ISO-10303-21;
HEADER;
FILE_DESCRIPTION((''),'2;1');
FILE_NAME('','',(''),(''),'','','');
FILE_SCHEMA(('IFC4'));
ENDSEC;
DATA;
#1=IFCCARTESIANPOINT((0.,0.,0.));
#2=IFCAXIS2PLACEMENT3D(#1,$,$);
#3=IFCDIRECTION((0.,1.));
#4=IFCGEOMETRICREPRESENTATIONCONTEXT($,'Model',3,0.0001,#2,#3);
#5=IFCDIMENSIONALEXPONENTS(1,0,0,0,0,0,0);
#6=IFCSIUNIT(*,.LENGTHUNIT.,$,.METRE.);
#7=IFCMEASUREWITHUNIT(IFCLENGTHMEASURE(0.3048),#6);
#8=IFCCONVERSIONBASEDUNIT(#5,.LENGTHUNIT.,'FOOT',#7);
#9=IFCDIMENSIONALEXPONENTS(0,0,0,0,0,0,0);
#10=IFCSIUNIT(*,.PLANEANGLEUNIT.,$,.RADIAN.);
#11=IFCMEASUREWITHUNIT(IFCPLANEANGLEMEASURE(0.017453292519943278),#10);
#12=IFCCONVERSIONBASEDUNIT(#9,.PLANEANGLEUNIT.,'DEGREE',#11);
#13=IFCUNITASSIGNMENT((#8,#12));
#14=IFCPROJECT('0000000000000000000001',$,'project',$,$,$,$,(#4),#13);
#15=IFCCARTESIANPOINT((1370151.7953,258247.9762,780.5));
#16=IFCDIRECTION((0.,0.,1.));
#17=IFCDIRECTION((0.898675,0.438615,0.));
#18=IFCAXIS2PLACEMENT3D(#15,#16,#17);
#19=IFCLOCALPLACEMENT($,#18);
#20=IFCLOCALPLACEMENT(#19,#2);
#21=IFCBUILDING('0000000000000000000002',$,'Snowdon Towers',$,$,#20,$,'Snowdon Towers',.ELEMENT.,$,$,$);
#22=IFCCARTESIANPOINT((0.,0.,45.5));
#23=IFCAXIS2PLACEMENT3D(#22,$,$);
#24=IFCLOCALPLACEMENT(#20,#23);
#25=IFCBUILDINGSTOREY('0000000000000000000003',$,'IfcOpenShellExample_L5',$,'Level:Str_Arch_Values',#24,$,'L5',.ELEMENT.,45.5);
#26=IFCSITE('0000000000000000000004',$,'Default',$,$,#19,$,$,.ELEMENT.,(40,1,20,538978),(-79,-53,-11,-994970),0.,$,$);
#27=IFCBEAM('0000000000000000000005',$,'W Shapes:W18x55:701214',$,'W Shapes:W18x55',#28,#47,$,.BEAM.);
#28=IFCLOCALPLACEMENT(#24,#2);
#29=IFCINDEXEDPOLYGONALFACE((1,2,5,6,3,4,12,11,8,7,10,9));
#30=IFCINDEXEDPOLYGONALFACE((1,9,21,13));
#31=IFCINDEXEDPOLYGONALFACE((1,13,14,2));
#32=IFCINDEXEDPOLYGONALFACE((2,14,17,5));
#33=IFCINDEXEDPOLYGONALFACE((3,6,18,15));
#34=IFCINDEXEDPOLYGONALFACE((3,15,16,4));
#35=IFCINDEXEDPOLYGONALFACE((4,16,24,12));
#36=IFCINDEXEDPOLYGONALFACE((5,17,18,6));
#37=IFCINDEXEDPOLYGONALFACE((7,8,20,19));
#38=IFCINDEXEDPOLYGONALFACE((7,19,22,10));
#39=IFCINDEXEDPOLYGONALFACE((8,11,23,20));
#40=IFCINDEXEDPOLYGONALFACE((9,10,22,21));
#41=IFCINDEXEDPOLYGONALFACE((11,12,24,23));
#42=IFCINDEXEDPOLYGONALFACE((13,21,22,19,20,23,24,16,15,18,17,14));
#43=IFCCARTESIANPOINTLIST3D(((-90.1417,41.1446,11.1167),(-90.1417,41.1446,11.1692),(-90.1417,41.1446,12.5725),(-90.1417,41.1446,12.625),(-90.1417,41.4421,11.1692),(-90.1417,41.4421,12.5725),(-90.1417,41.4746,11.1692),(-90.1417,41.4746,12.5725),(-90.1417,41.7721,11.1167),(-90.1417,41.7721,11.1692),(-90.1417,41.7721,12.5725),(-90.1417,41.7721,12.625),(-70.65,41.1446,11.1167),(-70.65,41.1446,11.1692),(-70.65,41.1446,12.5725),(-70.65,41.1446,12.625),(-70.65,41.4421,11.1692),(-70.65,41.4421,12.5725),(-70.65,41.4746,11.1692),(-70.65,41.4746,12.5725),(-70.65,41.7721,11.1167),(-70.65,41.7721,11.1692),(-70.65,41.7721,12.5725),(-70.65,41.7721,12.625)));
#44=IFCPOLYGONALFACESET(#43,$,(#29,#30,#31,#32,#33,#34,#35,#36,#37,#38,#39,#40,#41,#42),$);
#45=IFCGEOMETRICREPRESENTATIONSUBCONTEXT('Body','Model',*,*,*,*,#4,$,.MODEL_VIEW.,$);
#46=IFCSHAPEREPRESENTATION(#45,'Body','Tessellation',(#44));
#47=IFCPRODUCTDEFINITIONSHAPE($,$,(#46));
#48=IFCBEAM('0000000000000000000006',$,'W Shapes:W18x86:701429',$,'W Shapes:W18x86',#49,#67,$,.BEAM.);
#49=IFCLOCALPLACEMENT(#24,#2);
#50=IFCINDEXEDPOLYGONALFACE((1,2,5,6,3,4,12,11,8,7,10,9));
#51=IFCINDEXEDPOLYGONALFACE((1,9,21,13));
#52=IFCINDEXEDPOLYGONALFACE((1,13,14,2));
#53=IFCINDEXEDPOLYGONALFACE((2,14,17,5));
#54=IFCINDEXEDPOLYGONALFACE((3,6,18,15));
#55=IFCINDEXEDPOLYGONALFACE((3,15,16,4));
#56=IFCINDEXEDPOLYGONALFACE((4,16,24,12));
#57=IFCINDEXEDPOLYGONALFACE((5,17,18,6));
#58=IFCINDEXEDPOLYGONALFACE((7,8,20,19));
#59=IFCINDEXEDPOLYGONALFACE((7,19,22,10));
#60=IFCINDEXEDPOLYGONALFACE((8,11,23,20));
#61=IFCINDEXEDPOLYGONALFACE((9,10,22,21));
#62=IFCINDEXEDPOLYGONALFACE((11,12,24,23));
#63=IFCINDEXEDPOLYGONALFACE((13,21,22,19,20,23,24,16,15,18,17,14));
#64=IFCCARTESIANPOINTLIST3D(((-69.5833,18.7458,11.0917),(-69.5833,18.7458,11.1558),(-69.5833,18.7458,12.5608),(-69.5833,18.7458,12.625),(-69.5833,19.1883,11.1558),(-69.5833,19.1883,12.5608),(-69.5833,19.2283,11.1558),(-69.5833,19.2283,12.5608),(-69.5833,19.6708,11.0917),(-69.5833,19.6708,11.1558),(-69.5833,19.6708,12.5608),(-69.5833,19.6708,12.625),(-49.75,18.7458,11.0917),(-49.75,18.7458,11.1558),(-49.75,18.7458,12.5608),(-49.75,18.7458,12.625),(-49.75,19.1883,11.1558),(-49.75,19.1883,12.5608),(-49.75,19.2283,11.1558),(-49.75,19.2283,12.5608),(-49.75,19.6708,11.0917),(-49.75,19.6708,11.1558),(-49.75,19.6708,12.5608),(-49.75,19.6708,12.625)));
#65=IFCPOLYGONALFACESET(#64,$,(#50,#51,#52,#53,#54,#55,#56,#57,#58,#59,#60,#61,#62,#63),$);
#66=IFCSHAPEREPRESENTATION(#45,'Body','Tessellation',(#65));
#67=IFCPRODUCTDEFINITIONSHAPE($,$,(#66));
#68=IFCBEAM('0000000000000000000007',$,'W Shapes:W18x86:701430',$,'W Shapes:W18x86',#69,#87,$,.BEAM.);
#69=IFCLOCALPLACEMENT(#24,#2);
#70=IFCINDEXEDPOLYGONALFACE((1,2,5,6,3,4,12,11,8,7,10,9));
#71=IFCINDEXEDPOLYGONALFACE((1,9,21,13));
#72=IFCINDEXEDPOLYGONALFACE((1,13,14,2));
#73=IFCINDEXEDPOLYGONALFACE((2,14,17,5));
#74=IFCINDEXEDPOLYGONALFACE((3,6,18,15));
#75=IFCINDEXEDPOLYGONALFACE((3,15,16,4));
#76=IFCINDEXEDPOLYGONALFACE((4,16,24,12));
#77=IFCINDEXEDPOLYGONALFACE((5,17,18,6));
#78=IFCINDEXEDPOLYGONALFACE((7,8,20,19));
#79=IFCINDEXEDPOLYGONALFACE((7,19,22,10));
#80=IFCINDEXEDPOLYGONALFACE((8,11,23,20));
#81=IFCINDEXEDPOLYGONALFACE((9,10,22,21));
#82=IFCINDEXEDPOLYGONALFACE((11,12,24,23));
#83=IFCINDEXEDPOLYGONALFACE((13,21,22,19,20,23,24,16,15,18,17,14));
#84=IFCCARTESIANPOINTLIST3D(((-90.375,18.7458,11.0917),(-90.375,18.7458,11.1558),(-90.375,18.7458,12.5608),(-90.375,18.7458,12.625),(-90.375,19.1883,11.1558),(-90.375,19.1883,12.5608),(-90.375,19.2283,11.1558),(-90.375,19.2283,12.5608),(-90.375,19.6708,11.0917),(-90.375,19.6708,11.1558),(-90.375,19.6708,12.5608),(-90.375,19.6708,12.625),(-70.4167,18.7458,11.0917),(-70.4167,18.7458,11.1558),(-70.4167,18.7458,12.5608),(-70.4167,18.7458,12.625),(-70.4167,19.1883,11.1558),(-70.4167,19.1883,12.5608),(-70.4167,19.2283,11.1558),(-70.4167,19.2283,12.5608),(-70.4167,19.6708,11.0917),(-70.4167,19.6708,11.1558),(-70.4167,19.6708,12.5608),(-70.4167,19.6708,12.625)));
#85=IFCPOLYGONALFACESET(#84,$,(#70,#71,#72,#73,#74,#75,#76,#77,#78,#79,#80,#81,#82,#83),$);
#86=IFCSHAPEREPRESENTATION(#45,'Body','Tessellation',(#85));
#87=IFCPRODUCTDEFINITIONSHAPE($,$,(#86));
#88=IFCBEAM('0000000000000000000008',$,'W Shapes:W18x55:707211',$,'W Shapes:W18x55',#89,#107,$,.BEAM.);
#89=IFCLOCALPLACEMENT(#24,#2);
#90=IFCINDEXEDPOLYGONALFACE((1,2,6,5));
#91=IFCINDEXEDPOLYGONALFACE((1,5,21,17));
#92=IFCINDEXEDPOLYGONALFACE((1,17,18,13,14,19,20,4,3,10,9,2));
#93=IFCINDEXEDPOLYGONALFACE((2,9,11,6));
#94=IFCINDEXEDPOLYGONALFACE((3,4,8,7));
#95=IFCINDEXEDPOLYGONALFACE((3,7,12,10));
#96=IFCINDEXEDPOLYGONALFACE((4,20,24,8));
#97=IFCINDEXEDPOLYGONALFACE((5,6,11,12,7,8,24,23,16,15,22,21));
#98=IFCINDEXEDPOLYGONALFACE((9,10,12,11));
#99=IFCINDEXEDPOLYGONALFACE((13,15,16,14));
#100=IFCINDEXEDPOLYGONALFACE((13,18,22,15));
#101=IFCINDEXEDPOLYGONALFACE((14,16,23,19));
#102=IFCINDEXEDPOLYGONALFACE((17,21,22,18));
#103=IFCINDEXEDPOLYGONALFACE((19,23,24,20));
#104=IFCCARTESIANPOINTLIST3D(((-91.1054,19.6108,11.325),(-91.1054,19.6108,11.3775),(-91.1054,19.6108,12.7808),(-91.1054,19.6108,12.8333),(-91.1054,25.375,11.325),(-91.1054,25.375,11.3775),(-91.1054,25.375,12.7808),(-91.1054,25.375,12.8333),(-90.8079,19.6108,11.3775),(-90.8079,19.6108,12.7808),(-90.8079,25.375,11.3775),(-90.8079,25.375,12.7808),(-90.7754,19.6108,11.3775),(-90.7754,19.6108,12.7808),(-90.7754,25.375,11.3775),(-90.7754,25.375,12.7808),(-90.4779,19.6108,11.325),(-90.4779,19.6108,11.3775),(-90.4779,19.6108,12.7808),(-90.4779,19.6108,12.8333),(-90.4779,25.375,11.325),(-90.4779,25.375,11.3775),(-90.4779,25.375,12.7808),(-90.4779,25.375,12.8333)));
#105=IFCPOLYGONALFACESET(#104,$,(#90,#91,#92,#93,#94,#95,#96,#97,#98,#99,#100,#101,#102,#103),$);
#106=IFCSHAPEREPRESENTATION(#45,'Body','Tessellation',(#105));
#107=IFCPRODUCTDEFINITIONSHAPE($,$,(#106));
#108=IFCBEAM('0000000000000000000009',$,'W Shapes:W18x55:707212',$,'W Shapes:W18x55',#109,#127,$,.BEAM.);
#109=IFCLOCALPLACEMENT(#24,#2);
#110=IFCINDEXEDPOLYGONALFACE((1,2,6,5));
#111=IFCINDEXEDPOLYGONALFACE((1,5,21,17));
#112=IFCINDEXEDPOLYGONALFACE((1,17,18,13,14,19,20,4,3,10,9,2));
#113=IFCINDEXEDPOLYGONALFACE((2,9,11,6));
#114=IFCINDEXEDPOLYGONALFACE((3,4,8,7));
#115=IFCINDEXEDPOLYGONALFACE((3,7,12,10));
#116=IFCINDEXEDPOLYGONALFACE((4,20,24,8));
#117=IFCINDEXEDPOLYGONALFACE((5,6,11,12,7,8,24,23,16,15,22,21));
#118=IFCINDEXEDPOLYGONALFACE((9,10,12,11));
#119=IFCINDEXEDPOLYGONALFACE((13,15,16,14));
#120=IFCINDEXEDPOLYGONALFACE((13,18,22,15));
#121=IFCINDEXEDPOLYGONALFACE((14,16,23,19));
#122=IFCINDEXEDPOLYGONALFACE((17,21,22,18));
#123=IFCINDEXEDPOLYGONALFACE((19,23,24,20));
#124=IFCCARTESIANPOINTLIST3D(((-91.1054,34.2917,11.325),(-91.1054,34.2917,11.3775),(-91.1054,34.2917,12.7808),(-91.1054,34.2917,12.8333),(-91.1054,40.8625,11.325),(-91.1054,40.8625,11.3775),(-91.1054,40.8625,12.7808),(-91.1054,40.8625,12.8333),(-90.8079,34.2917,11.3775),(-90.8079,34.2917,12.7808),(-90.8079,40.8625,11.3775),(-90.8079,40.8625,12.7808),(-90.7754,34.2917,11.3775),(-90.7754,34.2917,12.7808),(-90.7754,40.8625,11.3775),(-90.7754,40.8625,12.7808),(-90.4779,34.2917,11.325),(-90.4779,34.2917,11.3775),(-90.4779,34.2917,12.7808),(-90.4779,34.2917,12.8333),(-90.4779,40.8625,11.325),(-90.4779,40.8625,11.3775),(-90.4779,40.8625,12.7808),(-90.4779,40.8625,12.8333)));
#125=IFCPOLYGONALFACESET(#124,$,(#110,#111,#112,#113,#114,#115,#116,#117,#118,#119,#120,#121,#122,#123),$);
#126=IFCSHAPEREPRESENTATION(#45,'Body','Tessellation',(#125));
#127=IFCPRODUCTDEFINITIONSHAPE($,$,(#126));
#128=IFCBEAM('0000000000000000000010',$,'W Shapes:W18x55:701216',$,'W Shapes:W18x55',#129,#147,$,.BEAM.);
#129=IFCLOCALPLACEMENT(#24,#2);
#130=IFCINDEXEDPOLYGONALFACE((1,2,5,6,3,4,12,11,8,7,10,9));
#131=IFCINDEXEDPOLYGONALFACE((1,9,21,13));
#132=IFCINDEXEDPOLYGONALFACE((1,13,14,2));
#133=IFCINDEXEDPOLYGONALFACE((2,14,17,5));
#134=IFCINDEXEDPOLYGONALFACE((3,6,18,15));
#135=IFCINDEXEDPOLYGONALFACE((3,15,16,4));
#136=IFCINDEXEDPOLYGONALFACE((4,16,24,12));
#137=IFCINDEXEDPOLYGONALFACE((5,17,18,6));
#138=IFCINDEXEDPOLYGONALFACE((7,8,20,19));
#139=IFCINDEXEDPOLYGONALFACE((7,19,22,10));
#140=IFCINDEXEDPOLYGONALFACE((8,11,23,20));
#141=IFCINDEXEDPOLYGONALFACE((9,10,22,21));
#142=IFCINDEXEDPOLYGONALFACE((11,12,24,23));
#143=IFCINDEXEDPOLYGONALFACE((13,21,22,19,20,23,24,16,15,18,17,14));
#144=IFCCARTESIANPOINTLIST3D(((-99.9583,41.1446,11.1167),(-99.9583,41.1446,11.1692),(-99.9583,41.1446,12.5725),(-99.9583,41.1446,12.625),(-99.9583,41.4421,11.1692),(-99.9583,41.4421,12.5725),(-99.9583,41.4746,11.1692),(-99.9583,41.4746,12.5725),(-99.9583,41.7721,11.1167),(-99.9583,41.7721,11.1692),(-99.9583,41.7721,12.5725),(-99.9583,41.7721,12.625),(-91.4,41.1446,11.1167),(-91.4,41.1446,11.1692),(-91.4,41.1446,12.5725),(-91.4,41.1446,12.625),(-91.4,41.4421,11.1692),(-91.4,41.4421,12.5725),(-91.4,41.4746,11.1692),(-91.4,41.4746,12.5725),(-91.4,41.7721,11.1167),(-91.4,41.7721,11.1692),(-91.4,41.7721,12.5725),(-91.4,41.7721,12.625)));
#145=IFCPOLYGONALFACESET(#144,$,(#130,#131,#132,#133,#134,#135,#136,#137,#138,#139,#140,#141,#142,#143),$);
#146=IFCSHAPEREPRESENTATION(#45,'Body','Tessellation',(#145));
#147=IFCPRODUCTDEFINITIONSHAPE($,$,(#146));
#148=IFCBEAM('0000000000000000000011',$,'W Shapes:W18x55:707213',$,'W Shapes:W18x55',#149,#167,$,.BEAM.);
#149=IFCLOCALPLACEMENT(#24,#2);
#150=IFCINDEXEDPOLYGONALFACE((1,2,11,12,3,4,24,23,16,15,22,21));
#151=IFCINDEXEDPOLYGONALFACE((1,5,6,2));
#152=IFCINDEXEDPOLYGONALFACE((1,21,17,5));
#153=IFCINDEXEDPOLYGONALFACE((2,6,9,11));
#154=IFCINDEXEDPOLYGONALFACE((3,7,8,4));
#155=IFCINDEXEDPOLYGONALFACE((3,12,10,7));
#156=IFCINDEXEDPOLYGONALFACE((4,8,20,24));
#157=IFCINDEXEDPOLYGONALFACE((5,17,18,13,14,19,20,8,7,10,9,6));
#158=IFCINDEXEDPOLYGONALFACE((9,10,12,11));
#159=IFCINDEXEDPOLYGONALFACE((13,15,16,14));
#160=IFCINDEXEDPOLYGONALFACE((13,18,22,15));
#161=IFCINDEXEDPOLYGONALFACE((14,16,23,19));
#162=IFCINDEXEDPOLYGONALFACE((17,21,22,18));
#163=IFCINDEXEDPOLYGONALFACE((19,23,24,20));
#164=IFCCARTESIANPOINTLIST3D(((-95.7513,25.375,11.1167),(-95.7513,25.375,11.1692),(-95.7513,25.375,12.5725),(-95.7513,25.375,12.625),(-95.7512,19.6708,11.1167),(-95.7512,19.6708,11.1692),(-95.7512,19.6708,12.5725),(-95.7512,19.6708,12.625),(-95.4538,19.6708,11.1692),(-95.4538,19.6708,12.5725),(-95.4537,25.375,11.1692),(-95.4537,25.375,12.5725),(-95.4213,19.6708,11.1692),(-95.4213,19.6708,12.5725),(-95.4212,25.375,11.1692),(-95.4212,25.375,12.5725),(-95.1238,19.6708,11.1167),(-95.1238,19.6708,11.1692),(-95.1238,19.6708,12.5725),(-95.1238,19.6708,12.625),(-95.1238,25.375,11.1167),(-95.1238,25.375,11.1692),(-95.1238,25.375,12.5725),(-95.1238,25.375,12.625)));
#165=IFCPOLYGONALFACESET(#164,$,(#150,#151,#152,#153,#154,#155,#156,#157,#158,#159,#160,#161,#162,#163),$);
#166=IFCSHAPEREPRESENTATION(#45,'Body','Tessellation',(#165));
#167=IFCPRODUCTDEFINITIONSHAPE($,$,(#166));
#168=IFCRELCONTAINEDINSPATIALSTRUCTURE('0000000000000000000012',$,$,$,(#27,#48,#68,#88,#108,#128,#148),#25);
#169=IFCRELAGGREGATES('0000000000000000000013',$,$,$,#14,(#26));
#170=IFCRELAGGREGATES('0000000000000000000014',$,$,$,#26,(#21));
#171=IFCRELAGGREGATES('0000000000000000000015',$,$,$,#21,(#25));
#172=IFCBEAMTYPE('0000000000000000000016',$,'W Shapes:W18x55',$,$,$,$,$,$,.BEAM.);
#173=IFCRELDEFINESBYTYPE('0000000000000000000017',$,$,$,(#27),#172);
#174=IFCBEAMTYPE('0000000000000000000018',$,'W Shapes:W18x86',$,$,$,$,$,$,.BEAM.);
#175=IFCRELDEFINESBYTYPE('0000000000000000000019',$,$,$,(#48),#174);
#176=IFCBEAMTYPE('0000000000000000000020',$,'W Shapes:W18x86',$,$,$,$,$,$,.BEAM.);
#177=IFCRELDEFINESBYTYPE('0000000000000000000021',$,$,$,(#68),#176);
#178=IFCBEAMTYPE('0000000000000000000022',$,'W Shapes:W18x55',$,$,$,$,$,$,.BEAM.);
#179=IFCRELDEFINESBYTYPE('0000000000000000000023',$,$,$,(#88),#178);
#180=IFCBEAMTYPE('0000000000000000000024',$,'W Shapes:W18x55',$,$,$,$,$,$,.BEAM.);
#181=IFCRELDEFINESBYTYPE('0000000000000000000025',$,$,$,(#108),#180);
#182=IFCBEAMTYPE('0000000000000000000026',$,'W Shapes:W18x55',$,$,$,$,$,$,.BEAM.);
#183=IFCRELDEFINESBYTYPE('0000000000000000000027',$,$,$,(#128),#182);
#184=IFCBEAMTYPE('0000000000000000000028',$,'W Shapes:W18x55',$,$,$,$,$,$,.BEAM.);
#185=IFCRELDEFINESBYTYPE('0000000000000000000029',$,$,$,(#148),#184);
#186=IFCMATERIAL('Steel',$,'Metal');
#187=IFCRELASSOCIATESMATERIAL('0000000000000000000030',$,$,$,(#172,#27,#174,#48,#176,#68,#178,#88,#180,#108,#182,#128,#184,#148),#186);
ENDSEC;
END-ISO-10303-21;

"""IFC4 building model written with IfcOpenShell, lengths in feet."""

from ifc_helpers import new_model, entity, si_unit, converted_unit, direction, frame, origin, place, context, subcontext, project, spatial, indexed_curve, outline, extrude, source, transform, mapped, material, type_object, type_shapes, element, save


model = new_model("IFC4")

# Units and contexts
model_context = context("Model", 3, precision=0.0001, world=origin(), true_north=direction((0.0, 1.0)))
body_context = subcontext(model_context, "Body", "Model", "MODEL_VIEW")
ifc_project = project(units=[converted_unit("LENGTHUNIT", "FOOT", entity("IfcLengthMeasure", 0.3048), si_unit("LENGTHUNIT", "METRE"), dimensions=[1, 0, 0, 0, 0, 0, 0]), converted_unit("PLANEANGLEUNIT", "DEGREE", entity("IfcPlaneAngleMeasure", 0.017453292519943278), si_unit("PLANEANGLEUNIT", "RADIAN"), dimensions=[0, 0, 0, 0, 0, 0, 0])], contexts=[model_context])

# Site, building, storey
site_placement = place(None, frame((1370151.7953, 258247.9762, 780.5), z_axis=(0.0, 0.0, 1.0), x_axis=(0.898675, 0.438615, 0.0)))
site = spatial("IfcSite", under=ifc_project, at=site_placement, Name="Default", CompositionType="ELEMENT", RefLatitude=(40, 1, 20, 538978), RefLongitude=(-79, -53, -11, -994970), RefElevation=0.0)
building_placement = place(site_placement, origin())
building = spatial("IfcBuilding", under=site, at=building_placement, Name="Snowdon Towers", LongName="Snowdon Towers", CompositionType="ELEMENT")
storey_placement = place(building_placement, frame((0.0, 0.0, 45.5)))
storey = spatial("IfcBuildingStorey", under=building, at=storey_placement, Name="IfcOpenShellExample_L5", ObjectType="Level:Str_Arch_Values", LongName="L5", CompositionType="ELEMENT", Elevation=45.5)

# Beams
ifc_material = material(Name="Steel", Category="Metal")
beam_type_1 = type_object("IfcBeamType", Name="W Shapes:W18x55", PredefinedType="BEAM", material=ifc_material)
shared_shape_1 = source(origin(), body_context, "Body", "SweptSolid", [
    extrude(outline(indexed_curve([(-0.3138, -0.7017), (-0.3138, -0.7542), (0.3138, -0.7542), (0.3138, -0.7017), (0.0162, -0.7017), (0.0162, 0.7017), (0.3138, 0.7017), (0.3138, 0.7542), (-0.3137, 0.7542), (-0.3137, 0.7017), (-0.0163, 0.7017), (-0.0163, -0.7017), (-0.3138, -0.7017)], self_intersect=False)), frame((-9.7875, 0.0, 0.0), z_axis=(-1.0, 0.0, 0.0), x_axis=(0.0, -1.0, 0.0)), (0.0, 0.0, -1.0), 19.4917),
])
type_shapes(beam_type_1, [shared_shape_1])
beam_1_placement = place(storey_placement, frame((-80.3542, 41.4583, 11.8708)))
element("IfcBeam", 1, at=beam_1_placement, inside=storey, type_object=beam_type_1, material=ifc_material, Name="W Shapes:W18x55:701214", ObjectType="W Shapes:W18x55", PredefinedType="BEAM", context=body_context, shape_type="MappedRepresentation", body=[
    mapped(shared_shape_1, transform((0.0, 0.0, 0.0), scale=1.0)),
])
beam_type_2 = type_object("IfcBeamType", Name="W Shapes:W18x86", PredefinedType="BEAM", material=ifc_material)
shared_shape_2 = source(origin(), body_context, "Body", "SweptSolid", [
    extrude(outline(indexed_curve([(-0.4625, -0.7025), (-0.4625, -0.7667), (0.4625, -0.7667), (0.4625, -0.7025), (0.02, -0.7025), (0.02, 0.7025), (0.4625, 0.7025), (0.4625, 0.7667), (-0.4625, 0.7667), (-0.4625, 0.7025), (-0.02, 0.7025), (-0.02, -0.7025), (-0.4625, -0.7025)], self_intersect=False)), frame((-9.9583, 0.0, 0.0), z_axis=(-1.0, 0.0, 0.0), x_axis=(0.0, -1.0, 0.0)), (0.0, 0.0, -1.0), 19.8333),
])
type_shapes(beam_type_2, [shared_shape_2])
beam_2_placement = place(storey_placement, frame((-59.625, 19.2083, 11.8583)))
element("IfcBeam", 2, at=beam_2_placement, inside=storey, type_object=beam_type_2, material=ifc_material, Name="W Shapes:W18x86:701429", ObjectType="W Shapes:W18x86", PredefinedType="BEAM", context=body_context, shape_type="MappedRepresentation", body=[
    mapped(shared_shape_2, transform((0.0, 0.0, 0.0), scale=1.0)),
])
beam_type_3 = type_object("IfcBeamType", Name="W Shapes:W18x86", PredefinedType="BEAM", material=ifc_material)
shared_shape_3 = source(origin(), body_context, "Body", "SweptSolid", [
    extrude(outline(indexed_curve([(-0.4625, -0.7025), (-0.4625, -0.7667), (0.4625, -0.7667), (0.4625, -0.7025), (0.02, -0.7025), (0.02, 0.7025), (0.4625, 0.7025), (0.4625, 0.7667), (-0.4625, 0.7667), (-0.4625, 0.7025), (-0.02, 0.7025), (-0.02, -0.7025), (-0.4625, -0.7025)], self_intersect=False)), frame((-10.0, 0.0, 0.0), z_axis=(-1.0, 0.0, 0.0), x_axis=(0.0, -1.0, 0.0)), (0.0, 0.0, -1.0), 19.9583),
])
type_shapes(beam_type_3, [shared_shape_3])
beam_3_placement = place(storey_placement, frame((-80.375, 19.2083, 11.8583)))
element("IfcBeam", 3, at=beam_3_placement, inside=storey, type_object=beam_type_3, material=ifc_material, Name="W Shapes:W18x86:701430", ObjectType="W Shapes:W18x86", PredefinedType="BEAM", context=body_context, shape_type="MappedRepresentation", body=[
    mapped(shared_shape_3, transform((0.0, 0.0, 0.0), scale=1.0)),
])
beam_type_4 = type_object("IfcBeamType", Name="W Shapes:W18x55", PredefinedType="BEAM", material=ifc_material)
shared_shape_4 = source(origin(), body_context, "Body", "SweptSolid", [
    extrude(outline(indexed_curve([(-0.3138, -0.7017), (-0.3138, -0.7542), (0.3138, -0.7542), (0.3138, -0.7017), (0.0162, -0.7017), (0.0162, 0.7017), (0.3138, 0.7017), (0.3138, 0.7542), (-0.3137, 0.7542), (-0.3137, 0.7017), (-0.0163, 0.7017), (-0.0163, -0.7017), (-0.3138, -0.7017)], self_intersect=False)), frame((-2.6737, 0.0, 0.0), z_axis=(-1.0, 0.0, 0.0), x_axis=(0.0, -1.0, 0.0)), (0.0, 0.0, -1.0), 5.7642),
])
type_shapes(beam_type_4, [shared_shape_4])
beam_4_placement = place(storey_placement, frame((-90.7917, 22.2846, 12.0792), z_axis=(0.0, 0.0, 1.0), x_axis=(0.0, 1.0, 0.0)))
element("IfcBeam", 4, at=beam_4_placement, inside=storey, type_object=beam_type_4, material=ifc_material, Name="W Shapes:W18x55:707211", ObjectType="W Shapes:W18x55", PredefinedType="BEAM", context=body_context, shape_type="MappedRepresentation", body=[
    mapped(shared_shape_4, transform((0.0, 0.0, 0.0), scale=1.0)),
])
beam_type_5 = type_object("IfcBeamType", Name="W Shapes:W18x55", PredefinedType="BEAM", material=ifc_material)
shared_shape_5 = source(origin(), body_context, "Body", "SweptSolid", [
    extrude(outline(indexed_curve([(-0.3138, -0.7017), (-0.3138, -0.7542), (0.3138, -0.7542), (0.3138, -0.7017), (0.0162, -0.7017), (0.0162, 0.7017), (0.3138, 0.7017), (0.3138, 0.7542), (-0.3137, 0.7542), (-0.3137, 0.7017), (-0.0163, 0.7017), (-0.0163, -0.7017), (-0.3138, -0.7017)], self_intersect=False)), frame((-3.1958, 0.0, 0.0), z_axis=(-1.0, 0.0, 0.0), x_axis=(0.0, -1.0, 0.0)), (0.0, 0.0, -1.0), 6.5708),
])
type_shapes(beam_type_5, [shared_shape_5])
beam_5_placement = place(storey_placement, frame((-90.7917, 37.6667, 12.0792), z_axis=(0.0, 0.0, 1.0), x_axis=(0.0, -1.0, 0.0)))
element("IfcBeam", 5, at=beam_5_placement, inside=storey, type_object=beam_type_5, material=ifc_material, Name="W Shapes:W18x55:707212", ObjectType="W Shapes:W18x55", PredefinedType="BEAM", context=body_context, shape_type="MappedRepresentation", body=[
    mapped(shared_shape_5, transform((0.0, 0.0, 0.0), scale=1.0)),
])
beam_type_6 = type_object("IfcBeamType", Name="W Shapes:W18x55", PredefinedType="BEAM", material=ifc_material)
shared_shape_6 = source(origin(), body_context, "Body", "SweptSolid", [
    extrude(outline(indexed_curve([(-0.3138, -0.7017), (-0.3138, -0.7542), (0.3138, -0.7542), (0.3138, -0.7017), (0.0162, -0.7017), (0.0162, 0.7017), (0.3138, 0.7017), (0.3138, 0.7542), (-0.3137, 0.7542), (-0.3137, 0.7017), (-0.0163, 0.7017), (-0.0163, -0.7017), (-0.3138, -0.7017)], self_intersect=False)), frame((-4.6042, 0.0, 0.0), z_axis=(-1.0, 0.0, 0.0), x_axis=(0.0, -1.0, 0.0)), (0.0, 0.0, -1.0), 8.5583),
])
type_shapes(beam_type_6, [shared_shape_6])
beam_6_placement = place(storey_placement, frame((-95.3542, 41.4583, 11.8708)))
element("IfcBeam", 6, at=beam_6_placement, inside=storey, type_object=beam_type_6, material=ifc_material, Name="W Shapes:W18x55:701216", ObjectType="W Shapes:W18x55", PredefinedType="BEAM", context=body_context, shape_type="MappedRepresentation", body=[
    mapped(shared_shape_6, transform((0.0, 0.0, 0.0), scale=1.0)),
])
beam_type_7 = type_object("IfcBeamType", Name="W Shapes:W18x55", PredefinedType="BEAM", material=ifc_material)
shared_shape_7 = source(origin(), body_context, "Body", "SweptSolid", [
    extrude(outline(indexed_curve([(-0.3138, -0.7017), (-0.3138, -0.7542), (0.3138, -0.7542), (0.3138, -0.7017), (0.0162, -0.7017), (0.0162, 0.7017), (0.3138, 0.7017), (0.3138, 0.7542), (-0.3137, 0.7542), (-0.3137, 0.7017), (-0.0163, 0.7017), (-0.0163, -0.7017), (-0.3138, -0.7017)], self_intersect=False)), frame((-2.6208, 0.0, 0.0), z_axis=(-1.0, 0.0, 0.0), x_axis=(0.0, -1.0, 0.0)), (0.0, 0.0, -1.0), 5.7042),
])
type_shapes(beam_type_7, [shared_shape_7])
beam_7_placement = place(storey_placement, frame((-95.4375, 22.2917, 11.8708), z_axis=(0.0, 0.0, 1.0), x_axis=(0.0, 1.0, 0.0)))
element("IfcBeam", 7, at=beam_7_placement, inside=storey, type_object=beam_type_7, material=ifc_material, Name="W Shapes:W18x55:707213", ObjectType="W Shapes:W18x55", PredefinedType="BEAM", context=body_context, shape_type="MappedRepresentation", body=[
    mapped(shared_shape_7, transform((0.0, 0.0, 0.0), scale=1.0)),
])

save(model, "model.ifc")
